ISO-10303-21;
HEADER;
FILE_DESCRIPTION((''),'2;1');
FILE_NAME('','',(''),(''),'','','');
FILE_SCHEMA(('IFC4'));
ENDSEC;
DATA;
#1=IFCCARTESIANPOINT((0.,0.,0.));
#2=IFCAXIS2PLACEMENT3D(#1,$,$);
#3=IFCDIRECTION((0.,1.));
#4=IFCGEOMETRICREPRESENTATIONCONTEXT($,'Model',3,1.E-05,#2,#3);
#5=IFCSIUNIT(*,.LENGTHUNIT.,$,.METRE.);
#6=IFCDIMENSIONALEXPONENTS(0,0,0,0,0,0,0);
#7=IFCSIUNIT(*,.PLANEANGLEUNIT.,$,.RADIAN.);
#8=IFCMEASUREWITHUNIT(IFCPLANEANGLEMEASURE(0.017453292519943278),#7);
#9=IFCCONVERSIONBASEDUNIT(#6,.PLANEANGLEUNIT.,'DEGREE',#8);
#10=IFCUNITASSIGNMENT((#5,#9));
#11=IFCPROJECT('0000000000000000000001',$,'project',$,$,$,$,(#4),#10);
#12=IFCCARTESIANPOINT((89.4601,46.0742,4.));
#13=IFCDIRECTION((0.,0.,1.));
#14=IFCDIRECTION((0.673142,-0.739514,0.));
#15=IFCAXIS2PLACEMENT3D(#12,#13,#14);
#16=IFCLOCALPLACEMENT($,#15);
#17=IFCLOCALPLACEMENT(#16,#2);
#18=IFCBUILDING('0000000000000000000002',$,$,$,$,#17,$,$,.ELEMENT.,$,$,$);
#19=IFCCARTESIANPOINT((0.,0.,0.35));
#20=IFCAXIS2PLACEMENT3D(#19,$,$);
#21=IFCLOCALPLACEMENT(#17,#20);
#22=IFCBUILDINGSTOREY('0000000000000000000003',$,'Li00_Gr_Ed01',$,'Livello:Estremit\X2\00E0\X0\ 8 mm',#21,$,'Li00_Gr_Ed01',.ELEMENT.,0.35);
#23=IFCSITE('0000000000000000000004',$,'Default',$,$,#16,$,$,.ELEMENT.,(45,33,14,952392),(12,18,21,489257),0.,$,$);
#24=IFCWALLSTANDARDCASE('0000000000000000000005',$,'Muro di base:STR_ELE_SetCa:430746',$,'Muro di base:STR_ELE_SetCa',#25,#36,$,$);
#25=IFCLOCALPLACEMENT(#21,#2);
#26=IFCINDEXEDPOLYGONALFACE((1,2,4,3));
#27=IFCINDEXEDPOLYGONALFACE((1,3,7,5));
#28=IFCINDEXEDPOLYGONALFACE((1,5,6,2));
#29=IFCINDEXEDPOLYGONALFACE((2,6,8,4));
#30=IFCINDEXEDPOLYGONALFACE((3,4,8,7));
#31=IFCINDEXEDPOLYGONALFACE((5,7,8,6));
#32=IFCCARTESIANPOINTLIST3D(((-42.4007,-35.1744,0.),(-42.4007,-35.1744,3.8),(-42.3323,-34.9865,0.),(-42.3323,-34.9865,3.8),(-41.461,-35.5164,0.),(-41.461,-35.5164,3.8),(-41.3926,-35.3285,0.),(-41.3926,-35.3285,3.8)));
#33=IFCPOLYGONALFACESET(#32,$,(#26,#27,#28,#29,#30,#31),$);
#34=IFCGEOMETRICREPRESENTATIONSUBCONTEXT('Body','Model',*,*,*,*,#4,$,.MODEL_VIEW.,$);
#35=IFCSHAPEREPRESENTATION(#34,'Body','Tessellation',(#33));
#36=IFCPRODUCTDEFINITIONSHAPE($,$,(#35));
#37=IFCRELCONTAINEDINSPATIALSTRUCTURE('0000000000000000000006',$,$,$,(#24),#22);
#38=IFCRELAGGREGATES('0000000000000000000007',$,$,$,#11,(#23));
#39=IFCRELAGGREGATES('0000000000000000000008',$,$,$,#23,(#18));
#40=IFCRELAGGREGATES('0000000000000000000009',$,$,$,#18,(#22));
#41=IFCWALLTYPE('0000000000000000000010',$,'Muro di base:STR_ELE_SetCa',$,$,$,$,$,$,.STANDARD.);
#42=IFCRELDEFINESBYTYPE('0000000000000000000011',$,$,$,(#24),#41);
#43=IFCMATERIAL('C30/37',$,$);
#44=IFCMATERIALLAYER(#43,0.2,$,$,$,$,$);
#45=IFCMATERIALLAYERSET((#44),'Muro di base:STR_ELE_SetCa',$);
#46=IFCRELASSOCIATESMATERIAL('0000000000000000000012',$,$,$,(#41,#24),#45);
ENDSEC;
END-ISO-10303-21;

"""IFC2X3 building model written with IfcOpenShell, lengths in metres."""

from ifc_helpers import new_model, entity, si_unit, converted_unit, direction, frame, frame_2d, origin, place, context, subcontext, project, spatial, rectangle, extrude, material, layer, layer_set, layer_usage, type_object, element, save


model = new_model("IFC2X3")

# Units and contexts
model_context = context("Model", 3, precision=1e-05, world=origin(), true_north=direction((0.0, 1.0)))
body_context = subcontext(model_context, "Body", "Model", "MODEL_VIEW")
ifc_project = project(units=[si_unit("LENGTHUNIT", "METRE"), converted_unit("PLANEANGLEUNIT", "DEGREE", entity("IfcPlaneAngleMeasure", 0.017453292519943278), si_unit("PLANEANGLEUNIT", "RADIAN"), dimensions=[0, 0, 0, 0, 0, 0, 0])], contexts=[model_context])

# Site, building, storey
site_placement = place(None, frame((89.4601, 46.0742, 4.0), z_axis=(0.0, 0.0, 1.0), x_axis=(0.673142, -0.739514, 0.0)))
site = spatial("IfcSite", under=ifc_project, at=site_placement, Name="Default", CompositionType="ELEMENT", RefLatitude=(45, 33, 14, 952392), RefLongitude=(12, 18, 21, 489257), RefElevation=0.0)
building_placement = place(site_placement, origin())
building = spatial("IfcBuilding", under=site, at=building_placement, CompositionType="ELEMENT")
storey_placement = place(building_placement, frame((0.0, 0.0, 0.35)))
storey = spatial("IfcBuildingStorey", under=building, at=storey_placement, Name="Li00_Gr_Ed01", ObjectType="Livello:Estremità 8 mm", LongName="Li00_Gr_Ed01", CompositionType="ELEMENT", Elevation=0.35)

# Shared definitions
ifc_material_1 = material(Name="C30/37")

# Wall
ifc_layer_1 = layer(ifc_material_1, 0.2)
ifc_layer_set_1 = layer_set([ifc_layer_1], Name="Muro di base:STR_ELE_SetCa")
ifc_layer_usage_1 = layer_usage(ifc_layer_set_1, "AXIS2", "NEGATIVE", 0.1)
wall_type_1 = type_object("IfcWallType", Name="Muro di base:STR_ELE_SetCa", PredefinedType="STANDARD", material=ifc_layer_set_1)
wall_1_placement = place(storey_placement, frame((-41.4268, -35.4224, 0.0), z_axis=(0.0, 0.0, 1.0), x_axis=(-0.939693, 0.34202, 0.0)))
element("IfcWallStandardCase", 1, at=wall_1_placement, inside=storey, type_object=wall_type_1, material=ifc_layer_usage_1, Name="Muro di base:STR_ELE_SetCa:430746", ObjectType="Muro di base:STR_ELE_SetCa", context=body_context, shape_type="SweptSolid", body=[
    extrude(rectangle(XDim=1.0, YDim=0.2, at=frame_2d((0.5, 0.0), x_axis=(-1.0, 0.0))), origin(), (0.0, 0.0, 1.0), 3.8),
])

save(model, "model.ifc")
